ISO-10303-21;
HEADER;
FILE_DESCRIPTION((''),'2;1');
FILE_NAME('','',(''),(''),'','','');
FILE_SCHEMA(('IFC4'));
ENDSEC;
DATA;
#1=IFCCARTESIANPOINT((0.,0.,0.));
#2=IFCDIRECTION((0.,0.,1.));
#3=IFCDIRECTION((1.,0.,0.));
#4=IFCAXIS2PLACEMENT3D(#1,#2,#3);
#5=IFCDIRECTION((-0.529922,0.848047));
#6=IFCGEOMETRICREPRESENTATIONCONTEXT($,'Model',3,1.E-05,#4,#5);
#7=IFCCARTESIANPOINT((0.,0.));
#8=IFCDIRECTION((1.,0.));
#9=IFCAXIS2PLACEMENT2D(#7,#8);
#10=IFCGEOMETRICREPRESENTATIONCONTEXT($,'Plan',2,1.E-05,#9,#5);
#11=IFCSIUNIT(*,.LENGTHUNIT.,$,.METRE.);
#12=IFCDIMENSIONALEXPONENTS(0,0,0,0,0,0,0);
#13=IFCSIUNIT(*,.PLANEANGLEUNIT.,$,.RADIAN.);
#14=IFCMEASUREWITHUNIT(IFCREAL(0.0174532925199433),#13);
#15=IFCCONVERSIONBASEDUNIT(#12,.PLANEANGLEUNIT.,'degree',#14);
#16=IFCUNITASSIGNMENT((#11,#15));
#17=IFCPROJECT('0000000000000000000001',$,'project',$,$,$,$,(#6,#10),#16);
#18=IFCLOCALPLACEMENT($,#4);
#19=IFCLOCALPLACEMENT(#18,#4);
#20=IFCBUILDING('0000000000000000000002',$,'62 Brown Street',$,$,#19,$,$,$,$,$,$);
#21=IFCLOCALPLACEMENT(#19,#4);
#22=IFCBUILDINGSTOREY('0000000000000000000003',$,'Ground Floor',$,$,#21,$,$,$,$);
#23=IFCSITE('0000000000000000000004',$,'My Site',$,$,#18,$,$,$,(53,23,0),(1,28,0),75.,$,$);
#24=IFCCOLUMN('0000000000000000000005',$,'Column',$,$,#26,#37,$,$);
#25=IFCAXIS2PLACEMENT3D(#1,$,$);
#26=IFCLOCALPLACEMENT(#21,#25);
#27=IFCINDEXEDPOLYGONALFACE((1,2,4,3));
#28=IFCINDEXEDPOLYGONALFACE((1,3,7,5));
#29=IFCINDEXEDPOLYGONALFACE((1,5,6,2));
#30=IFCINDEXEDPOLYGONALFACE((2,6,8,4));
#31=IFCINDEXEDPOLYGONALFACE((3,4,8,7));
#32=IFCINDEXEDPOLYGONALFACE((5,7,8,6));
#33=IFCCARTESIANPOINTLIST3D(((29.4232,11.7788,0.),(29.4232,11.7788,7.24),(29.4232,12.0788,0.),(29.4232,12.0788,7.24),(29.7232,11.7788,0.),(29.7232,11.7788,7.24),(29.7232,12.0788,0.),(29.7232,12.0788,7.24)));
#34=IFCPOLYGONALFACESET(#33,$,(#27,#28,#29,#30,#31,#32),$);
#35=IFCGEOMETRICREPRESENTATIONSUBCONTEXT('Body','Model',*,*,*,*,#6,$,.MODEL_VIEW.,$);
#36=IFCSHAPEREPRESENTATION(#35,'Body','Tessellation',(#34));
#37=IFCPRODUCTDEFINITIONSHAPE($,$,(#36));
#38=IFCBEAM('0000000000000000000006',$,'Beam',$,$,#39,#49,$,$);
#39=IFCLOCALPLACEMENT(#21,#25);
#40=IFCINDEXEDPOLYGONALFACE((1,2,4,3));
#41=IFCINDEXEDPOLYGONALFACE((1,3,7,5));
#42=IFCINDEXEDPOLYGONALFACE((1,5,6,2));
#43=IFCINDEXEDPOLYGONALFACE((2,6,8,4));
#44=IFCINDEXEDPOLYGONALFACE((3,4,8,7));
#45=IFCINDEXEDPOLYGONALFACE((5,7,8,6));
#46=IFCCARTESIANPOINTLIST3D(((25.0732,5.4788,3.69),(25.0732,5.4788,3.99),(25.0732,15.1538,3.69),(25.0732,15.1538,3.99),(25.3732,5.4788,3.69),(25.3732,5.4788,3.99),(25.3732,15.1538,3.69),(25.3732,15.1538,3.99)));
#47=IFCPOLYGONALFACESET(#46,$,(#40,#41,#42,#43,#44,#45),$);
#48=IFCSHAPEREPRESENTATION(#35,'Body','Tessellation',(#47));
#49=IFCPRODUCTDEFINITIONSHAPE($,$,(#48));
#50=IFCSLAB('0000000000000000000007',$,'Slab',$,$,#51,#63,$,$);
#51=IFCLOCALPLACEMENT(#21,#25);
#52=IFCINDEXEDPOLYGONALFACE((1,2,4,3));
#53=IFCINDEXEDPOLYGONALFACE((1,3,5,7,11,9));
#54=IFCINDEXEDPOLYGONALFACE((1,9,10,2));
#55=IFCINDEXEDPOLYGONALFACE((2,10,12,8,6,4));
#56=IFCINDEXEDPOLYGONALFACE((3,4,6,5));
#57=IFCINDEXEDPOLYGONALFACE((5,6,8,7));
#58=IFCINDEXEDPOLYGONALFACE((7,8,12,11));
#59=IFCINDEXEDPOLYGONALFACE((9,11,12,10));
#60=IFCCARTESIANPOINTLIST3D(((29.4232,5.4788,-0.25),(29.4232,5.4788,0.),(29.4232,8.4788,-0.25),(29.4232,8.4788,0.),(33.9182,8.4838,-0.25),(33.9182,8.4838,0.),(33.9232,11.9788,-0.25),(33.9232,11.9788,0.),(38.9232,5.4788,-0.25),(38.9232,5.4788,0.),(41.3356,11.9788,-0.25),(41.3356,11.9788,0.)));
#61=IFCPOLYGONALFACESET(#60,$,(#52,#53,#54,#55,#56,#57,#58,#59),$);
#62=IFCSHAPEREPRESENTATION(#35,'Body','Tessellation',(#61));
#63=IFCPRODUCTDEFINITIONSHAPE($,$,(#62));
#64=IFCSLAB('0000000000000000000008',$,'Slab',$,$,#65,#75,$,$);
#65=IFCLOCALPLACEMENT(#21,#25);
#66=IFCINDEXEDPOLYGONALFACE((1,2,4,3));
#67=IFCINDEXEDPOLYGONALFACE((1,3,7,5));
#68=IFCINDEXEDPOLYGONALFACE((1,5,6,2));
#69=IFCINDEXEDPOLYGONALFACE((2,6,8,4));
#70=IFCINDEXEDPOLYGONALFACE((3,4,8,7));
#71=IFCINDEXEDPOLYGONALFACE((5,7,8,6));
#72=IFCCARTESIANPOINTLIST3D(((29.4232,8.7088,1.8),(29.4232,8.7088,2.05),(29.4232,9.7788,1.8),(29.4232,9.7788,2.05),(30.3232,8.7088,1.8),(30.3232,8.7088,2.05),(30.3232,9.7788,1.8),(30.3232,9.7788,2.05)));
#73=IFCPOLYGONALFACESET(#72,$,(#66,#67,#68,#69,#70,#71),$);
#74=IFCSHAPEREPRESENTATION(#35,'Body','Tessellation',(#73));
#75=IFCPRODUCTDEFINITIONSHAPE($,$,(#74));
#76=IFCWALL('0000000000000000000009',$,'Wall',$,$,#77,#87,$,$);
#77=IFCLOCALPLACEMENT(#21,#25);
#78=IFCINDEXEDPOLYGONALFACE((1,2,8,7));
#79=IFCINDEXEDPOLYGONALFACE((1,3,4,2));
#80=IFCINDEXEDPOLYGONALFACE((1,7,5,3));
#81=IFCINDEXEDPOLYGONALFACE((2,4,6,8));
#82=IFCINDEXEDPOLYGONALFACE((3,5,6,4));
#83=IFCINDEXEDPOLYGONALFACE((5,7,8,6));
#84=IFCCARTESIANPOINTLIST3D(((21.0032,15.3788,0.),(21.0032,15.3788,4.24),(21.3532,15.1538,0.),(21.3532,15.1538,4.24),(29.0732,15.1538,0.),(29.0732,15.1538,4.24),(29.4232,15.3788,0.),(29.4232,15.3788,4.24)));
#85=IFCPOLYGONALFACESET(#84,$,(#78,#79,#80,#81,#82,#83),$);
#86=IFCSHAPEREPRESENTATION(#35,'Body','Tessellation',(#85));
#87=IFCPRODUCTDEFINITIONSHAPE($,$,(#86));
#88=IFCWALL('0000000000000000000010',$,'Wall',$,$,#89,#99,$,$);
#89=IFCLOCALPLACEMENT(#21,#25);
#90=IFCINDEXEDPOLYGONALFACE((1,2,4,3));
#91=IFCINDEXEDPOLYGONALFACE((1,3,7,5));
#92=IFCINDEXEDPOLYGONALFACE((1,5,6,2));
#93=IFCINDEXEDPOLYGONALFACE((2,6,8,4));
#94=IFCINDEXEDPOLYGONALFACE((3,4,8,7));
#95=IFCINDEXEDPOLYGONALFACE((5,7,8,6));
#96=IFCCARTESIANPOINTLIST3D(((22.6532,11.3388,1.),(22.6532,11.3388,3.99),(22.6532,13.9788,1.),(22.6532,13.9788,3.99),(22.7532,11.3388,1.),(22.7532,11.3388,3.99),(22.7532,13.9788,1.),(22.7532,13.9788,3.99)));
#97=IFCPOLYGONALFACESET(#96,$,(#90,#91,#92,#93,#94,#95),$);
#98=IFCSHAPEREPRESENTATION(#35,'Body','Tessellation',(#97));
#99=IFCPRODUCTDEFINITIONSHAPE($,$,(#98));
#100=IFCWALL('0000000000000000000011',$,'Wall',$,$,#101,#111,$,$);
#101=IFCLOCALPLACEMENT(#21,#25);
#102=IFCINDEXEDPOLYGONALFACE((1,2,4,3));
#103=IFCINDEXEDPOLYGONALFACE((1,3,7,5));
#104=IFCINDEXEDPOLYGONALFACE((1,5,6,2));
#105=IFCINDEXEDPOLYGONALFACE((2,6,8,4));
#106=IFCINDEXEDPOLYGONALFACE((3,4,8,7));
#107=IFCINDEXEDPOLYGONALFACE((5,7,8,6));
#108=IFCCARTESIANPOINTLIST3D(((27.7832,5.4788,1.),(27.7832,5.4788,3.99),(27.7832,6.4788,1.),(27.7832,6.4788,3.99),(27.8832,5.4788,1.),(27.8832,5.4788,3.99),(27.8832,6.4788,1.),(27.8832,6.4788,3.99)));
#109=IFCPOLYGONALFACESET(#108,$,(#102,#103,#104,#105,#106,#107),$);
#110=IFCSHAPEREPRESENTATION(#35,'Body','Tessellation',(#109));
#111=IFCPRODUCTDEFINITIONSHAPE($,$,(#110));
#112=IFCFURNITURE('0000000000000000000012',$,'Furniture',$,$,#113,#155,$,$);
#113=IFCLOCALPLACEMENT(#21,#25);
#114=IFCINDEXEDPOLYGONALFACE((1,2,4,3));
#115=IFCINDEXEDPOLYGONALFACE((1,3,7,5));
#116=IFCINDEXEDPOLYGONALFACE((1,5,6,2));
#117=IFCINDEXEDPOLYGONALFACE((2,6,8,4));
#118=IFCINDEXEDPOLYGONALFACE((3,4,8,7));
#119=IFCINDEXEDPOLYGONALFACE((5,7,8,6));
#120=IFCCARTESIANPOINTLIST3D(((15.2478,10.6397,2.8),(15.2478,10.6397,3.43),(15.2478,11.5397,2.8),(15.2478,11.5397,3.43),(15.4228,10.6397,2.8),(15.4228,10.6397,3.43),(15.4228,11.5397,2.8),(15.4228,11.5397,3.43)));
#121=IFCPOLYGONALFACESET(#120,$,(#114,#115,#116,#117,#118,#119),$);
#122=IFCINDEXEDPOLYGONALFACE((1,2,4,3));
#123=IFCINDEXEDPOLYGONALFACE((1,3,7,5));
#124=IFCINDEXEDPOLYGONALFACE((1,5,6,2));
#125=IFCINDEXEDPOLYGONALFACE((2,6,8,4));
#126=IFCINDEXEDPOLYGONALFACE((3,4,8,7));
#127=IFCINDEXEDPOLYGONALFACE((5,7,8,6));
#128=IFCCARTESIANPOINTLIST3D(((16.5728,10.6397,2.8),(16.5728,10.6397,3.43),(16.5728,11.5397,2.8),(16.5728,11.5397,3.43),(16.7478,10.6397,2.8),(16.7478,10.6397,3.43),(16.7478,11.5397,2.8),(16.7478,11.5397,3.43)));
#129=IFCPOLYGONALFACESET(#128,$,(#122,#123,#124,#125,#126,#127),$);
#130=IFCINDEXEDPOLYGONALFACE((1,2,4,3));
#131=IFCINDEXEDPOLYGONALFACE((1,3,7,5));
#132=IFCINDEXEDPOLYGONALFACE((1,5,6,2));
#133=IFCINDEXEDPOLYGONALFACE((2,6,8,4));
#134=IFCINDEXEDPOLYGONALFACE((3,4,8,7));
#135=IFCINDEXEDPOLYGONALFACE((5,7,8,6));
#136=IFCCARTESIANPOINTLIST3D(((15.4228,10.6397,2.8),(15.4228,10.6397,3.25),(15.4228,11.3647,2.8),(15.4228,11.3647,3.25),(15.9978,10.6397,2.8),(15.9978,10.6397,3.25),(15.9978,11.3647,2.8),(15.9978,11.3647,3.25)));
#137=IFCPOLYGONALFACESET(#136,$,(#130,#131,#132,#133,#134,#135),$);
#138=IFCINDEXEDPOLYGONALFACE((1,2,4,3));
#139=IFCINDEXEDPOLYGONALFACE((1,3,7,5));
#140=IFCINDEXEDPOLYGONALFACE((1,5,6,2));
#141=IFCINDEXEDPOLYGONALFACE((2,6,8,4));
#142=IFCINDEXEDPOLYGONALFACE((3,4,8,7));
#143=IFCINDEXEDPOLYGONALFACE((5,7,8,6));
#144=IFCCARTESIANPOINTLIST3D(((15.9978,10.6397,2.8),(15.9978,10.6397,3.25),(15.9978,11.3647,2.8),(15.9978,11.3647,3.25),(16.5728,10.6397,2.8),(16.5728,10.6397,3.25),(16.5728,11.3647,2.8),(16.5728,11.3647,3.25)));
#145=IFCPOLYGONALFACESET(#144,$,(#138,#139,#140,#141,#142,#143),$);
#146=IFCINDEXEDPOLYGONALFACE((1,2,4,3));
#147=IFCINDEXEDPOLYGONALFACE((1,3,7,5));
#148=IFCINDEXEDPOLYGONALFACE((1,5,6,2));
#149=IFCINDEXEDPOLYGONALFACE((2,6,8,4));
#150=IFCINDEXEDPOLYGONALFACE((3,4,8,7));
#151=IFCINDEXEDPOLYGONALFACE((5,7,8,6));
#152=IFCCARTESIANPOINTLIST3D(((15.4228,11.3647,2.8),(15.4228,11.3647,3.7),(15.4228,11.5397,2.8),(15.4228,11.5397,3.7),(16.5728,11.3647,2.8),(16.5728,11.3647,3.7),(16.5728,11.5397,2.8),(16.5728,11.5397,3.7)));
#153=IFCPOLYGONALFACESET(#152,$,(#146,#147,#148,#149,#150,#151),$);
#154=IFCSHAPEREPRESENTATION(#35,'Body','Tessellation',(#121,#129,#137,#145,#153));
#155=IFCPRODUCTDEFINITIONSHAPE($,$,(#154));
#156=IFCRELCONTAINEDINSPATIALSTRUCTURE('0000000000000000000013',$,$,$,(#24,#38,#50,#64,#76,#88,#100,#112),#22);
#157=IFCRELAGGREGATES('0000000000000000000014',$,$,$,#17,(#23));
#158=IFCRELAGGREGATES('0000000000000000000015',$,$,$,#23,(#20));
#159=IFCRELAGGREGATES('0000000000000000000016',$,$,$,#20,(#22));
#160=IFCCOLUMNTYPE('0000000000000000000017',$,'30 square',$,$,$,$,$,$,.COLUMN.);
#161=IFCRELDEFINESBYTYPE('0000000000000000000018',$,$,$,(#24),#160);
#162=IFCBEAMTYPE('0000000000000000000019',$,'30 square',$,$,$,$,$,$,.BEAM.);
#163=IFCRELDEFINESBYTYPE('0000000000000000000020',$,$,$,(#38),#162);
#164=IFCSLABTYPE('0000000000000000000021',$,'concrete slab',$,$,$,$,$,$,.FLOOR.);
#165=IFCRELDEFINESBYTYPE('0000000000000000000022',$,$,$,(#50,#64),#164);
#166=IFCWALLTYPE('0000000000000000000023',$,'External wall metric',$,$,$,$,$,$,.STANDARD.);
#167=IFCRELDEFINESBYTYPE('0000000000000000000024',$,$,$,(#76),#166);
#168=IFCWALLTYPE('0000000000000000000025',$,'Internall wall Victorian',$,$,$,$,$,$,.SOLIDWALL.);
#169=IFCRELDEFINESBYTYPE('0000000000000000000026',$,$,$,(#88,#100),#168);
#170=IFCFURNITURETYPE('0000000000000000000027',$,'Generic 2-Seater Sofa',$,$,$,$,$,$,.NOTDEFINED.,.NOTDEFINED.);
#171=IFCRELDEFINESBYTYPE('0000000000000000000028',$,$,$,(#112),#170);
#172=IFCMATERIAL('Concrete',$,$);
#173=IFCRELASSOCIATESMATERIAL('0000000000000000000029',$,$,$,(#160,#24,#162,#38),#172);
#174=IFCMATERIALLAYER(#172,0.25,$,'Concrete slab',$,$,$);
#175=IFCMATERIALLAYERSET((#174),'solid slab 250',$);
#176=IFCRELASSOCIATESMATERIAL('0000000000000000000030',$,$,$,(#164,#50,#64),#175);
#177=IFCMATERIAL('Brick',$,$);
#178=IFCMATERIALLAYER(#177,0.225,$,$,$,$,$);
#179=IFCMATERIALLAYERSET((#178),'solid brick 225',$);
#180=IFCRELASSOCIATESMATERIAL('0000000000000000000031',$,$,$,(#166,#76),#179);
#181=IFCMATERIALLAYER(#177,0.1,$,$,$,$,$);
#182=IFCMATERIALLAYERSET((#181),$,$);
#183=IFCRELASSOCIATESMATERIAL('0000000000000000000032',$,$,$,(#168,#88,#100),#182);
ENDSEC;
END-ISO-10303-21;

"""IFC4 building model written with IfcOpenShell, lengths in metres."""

from ifc_helpers import new_model, entity, si_unit, converted_unit, direction, frame, origin_with_axes, origin_2d_with_axis, place, context, subcontext, project, spatial, line, indexed_curve, rectangle, outline, extrude, clip, halfspace, shape, source, transform, mapped, material, layer, layer_set, layer_usage, material_profile, profile_set, profile_usage, type_object, type_shapes, element, save


model = new_model("IFC4")

# Units and contexts
model_context = context("Model", 3, precision=1e-05, world=origin_with_axes(), true_north=direction((-0.529922, 0.848047)))
plan_context = context("Plan", 2, precision=1e-05, world=origin_2d_with_axis(), true_north=direction((-0.529922, 0.848047)))
body_context_1 = subcontext(model_context, "Body", "Model", "MODEL_VIEW")
body_context_2 = subcontext(plan_context, "Body", "Plan", "PLAN_VIEW")
ifc_project = project(units=[si_unit("LENGTHUNIT", "METRE"), converted_unit("PLANEANGLEUNIT", "degree", entity("IfcReal", 0.0174532925199433), si_unit("PLANEANGLEUNIT", "RADIAN"), dimensions=[0, 0, 0, 0, 0, 0, 0])], contexts=[model_context, plan_context])

# Site, building, storey
site_placement = place(None, origin_with_axes())
site = spatial("IfcSite", under=ifc_project, at=site_placement, Name="My Site", RefLatitude=(53, 23, 0), RefLongitude=(1, 28, 0), RefElevation=75.0)
building_placement = place(site_placement, origin_with_axes())
building = spatial("IfcBuilding", under=site, at=building_placement, Name="62 Brown Street")
storey_placement = place(building_placement, origin_with_axes())
storey = spatial("IfcBuildingStorey", under=building, at=storey_placement, Name="Ground Floor")

# Column
ifc_material_1 = material(Name="Concrete")
ifc_material_profile_1 = material_profile(ifc_material_1, rectangle(XDim=0.3, YDim=0.3))
ifc_profile_set_1 = profile_set([ifc_material_profile_1])
ifc_profile_usage_1 = profile_usage(ifc_profile_set_1, cardinal=5)
column_type = type_object("IfcColumnType", Name="30 square", PredefinedType="COLUMN", material=ifc_profile_set_1)
column_1_placement = place(storey_placement, frame((29.5732, 11.9288, 0.0), z_axis=(0.0, 0.0, 1.0), x_axis=(1.0, 0.0, 0.0)))
element("IfcColumn", 1, at=column_1_placement, inside=storey, type_object=column_type, material=ifc_profile_usage_1, Name="Column", context=body_context_1, shape_type="SweptSolid", body=[
    extrude(rectangle(XDim=0.3, YDim=0.3), origin_with_axes(), (0.0, 0.0, 1.0), 7.24),
])

# Beam
ifc_material_profile_2 = material_profile(ifc_material_1, rectangle(XDim=0.3, YDim=0.3))
ifc_profile_set_2 = profile_set([ifc_material_profile_2])
ifc_profile_usage_2 = profile_usage(ifc_profile_set_2, cardinal=5)
beam_type = type_object("IfcBeamType", Name="30 square", PredefinedType="BEAM", material=ifc_profile_set_2)
beam_placement = place(storey_placement, frame((25.2232, 5.4788, 3.84), z_axis=(0.0, 1.0, 0.0), x_axis=(-1.0, 0.0, 0.0)))
element("IfcBeam", 2, at=beam_placement, inside=storey, type_object=beam_type, material=ifc_profile_usage_2, Name="Beam", context=body_context_1, shape_type="SweptSolid", body=[
    extrude(rectangle(XDim=0.3, YDim=0.3), origin_with_axes(), (0.0, 0.0, 1.0), 9.675),
])

# Slabs
ifc_layer_1 = layer(ifc_material_1, 0.25, Name="Concrete slab")
ifc_layer_set_1 = layer_set([ifc_layer_1], Name="solid slab 250")
ifc_layer_usage_1 = layer_usage(ifc_layer_set_1, "AXIS3", "POSITIVE", 0.0)
slab_type = type_object("IfcSlabType", Name="concrete slab", PredefinedType="FLOOR", material=ifc_layer_set_1)
slab_1_placement = place(storey_placement, frame((29.4232, 5.4788, -0.25), z_axis=(0.0, 0.0, 1.0), x_axis=(1.0, 0.0, 0.0)))
element("IfcSlab", 3, at=slab_1_placement, inside=storey, type_object=slab_type, material=ifc_layer_usage_1, Name="Slab", context=body_context_1, shape_type="SweptSolid", body=[
    extrude(outline(indexed_curve([(0.0, 0.0), (9.5, 0.0), (11.9124, 6.5), (0.0, 3.0), (4.5, 6.5), (4.495, 3.005)], segments=[line(1, 2), line(2, 3), line(3, 5), line(5, 6), line(6, 4), line(4, 1)], self_intersect=False)), None, (0.0, 0.0, 1.0), 0.25),
])
ifc_layer_usage_2 = layer_usage(ifc_layer_set_1, "AXIS3", "POSITIVE", 0.0)
slab_2_placement = place(storey_placement, frame((29.4232, 8.7088, 1.8), z_axis=(0.0, 0.0, 1.0), x_axis=(1.0, 0.0, 0.0)))
element("IfcSlab", 4, at=slab_2_placement, inside=storey, type_object=slab_type, material=ifc_layer_usage_2, Name="Slab", context=body_context_1, shape_type="SweptSolid", body=[
    extrude(outline(indexed_curve([(0.9, 1.07), (0.9, 0.0), (0.0, 0.0), (0.0, 1.07)], segments=[line(3, 2), line(2, 1), line(1, 4), line(4, 3)], self_intersect=False)), None, (0.0, 0.0, 1.0), 0.25),
])

# Walls
ifc_material_2 = material(Name="Brick")
ifc_layer_2 = layer(ifc_material_2, 0.225)
ifc_layer_set_2 = layer_set([ifc_layer_2], Name="solid brick 225")
wall_type_1 = type_object("IfcWallType", Name="External wall metric", PredefinedType="STANDARD", material=ifc_layer_set_2)
ifc_layer_usage_3 = layer_usage(ifc_layer_set_2, "AXIS2", "POSITIVE", 0.0)
wall_1_placement = place(storey_placement, frame((29.4232, 15.3788, 0.0), z_axis=(0.0, 0.0, 1.0), x_axis=(-1.0, 0.0, 0.0)))
element("IfcWall", 5, at=wall_1_placement, inside=storey, type_object=wall_type_1, material=ifc_layer_usage_3, Name="Wall", context=body_context_1, shape_type="Clipping", body=[
    clip(clip(extrude(outline(indexed_curve([(0.0, 0.0), (0.0, 0.225), (8.42, 0.225), (8.42, 0.0), (0.0, 0.0)], self_intersect=False)), origin_with_axes(), (0.0, 0.0, 1.0), 4.24), halfspace(frame((8.42, 0.0, 0.0), z_axis=(0.540756, 0.841179, 0.0), x_axis=(-0.841179, 0.540756, 0.0)), False)), halfspace(frame((0.0, 0.0, 0.0), z_axis=(-0.540758, 0.841178, 0.0), x_axis=(0.841178, 0.540758, 0.0)), False)),
])
ifc_layer_3 = layer(ifc_material_2, 0.1)
ifc_layer_set_3 = layer_set([ifc_layer_3])
ifc_layer_usage_4 = layer_usage(ifc_layer_set_3, "AXIS2", "POSITIVE", 0.0)
wall_type_2 = type_object("IfcWallType", Name="Internall wall Victorian", PredefinedType="SOLIDWALL", material=ifc_layer_set_3)
wall_2_placement = place(storey_placement, frame((22.7532, 11.3388, 1.0), z_axis=(0.0, 0.0, 1.0), x_axis=(0.0, 1.0, 0.0)))
element("IfcWall", 6, at=wall_2_placement, inside=storey, type_object=wall_type_2, material=ifc_layer_usage_4, Name="Wall", context=body_context_1, shape_type="SweptSolid", body=[
    extrude(outline(indexed_curve([(0.0, 0.0), (0.0, 0.1), (2.64, 0.1), (2.64, 0.0), (0.0, 0.0)], self_intersect=False)), origin_with_axes(), (0.0, 0.0, 1.0), 2.99),
])
ifc_layer_usage_5 = layer_usage(ifc_layer_set_3, "AXIS2", "POSITIVE", 0.0)
wall_3_placement = place(storey_placement, frame((27.8832, 5.4788, 1.0), z_axis=(0.0, 0.0, 1.0), x_axis=(0.0, 1.0, 0.0)))
element("IfcWall", 7, at=wall_3_placement, inside=storey, type_object=wall_type_2, material=ifc_layer_usage_5, Name="Wall", context=body_context_1, shape_type="SweptSolid", body=[
    extrude(outline(indexed_curve([(0.0, 0.0), (0.0, 0.1), (1.0, 0.1), (1.0, 0.0), (0.0, 0.0)], self_intersect=False)), origin_with_axes(), (0.0, 0.0, 1.0), 2.99),
])

# Furniture
furniture_type_1 = type_object("IfcFurnitureType", Name="Generic 2-Seater Sofa", AssemblyPlace="NOTDEFINED", PredefinedType="NOTDEFINED")
shared_shape_1 = source(origin_with_axes(), body_context_1, "Body", "SweptSolid", [
    extrude(outline(indexed_curve([(0.0, 0.0), (0.175, 0.0), (0.175, 0.9), (0.0, 0.9)], segments=[line(1, 2, 3, 4, 1)])), frame((-0.75, -0.9, 0.0), z_axis=(0.0, 0.0, 1.0), x_axis=(1.0, 0.0, 0.0)), (0.0, 0.0, 1.0), 0.63),
    extrude(outline(indexed_curve([(0.0, 0.0), (0.175, 0.0), (0.175, 0.9), (0.0, 0.9)], segments=[line(1, 2, 3, 4, 1)])), frame((0.575, -0.9, 0.0), z_axis=(0.0, 0.0, 1.0), x_axis=(1.0, 0.0, 0.0)), (0.0, 0.0, 1.0), 0.63),
    extrude(outline(indexed_curve([(0.175, 0.0), (0.75, 0.0), (0.75, 0.725), (0.175, 0.725)], segments=[line(1, 2, 3, 4, 1)])), frame((-0.75, -0.9, 0.0), z_axis=(0.0, 0.0, 1.0), x_axis=(1.0, 0.0, 0.0)), (0.0, 0.0, 1.0), 0.45),
    extrude(outline(indexed_curve([(0.75, 0.0), (1.325, 0.0), (1.325, 0.725), (0.75, 0.725)], segments=[line(1, 2, 3, 4, 1)])), frame((-0.75, -0.9, 0.0), z_axis=(0.0, 0.0, 1.0), x_axis=(1.0, 0.0, 0.0)), (0.0, 0.0, 1.0), 0.45),
    extrude(outline(indexed_curve([(0.175, 0.725), (1.325, 0.725), (1.325, 0.9), (0.175, 0.9)], segments=[line(1, 2, 3, 4, 1)])), frame((-0.75, -0.9, 0.0), z_axis=(0.0, 0.0, 1.0), x_axis=(1.0, 0.0, 0.0)), (0.0, 0.0, 1.0), 0.9),
])
shared_shape_2 = source(origin_with_axes(), body_context_2, "Body", "Curve2D", [
    entity("IfcIndexedPolyCurve", entity("IfcCartesianPointList2D", [[-0.75, -0.9], [-0.575, -0.9], [-0.575, 0.0], [-0.75, 0.0]]), [entity("IfcLineIndex", [1, 2, 3, 4, 1])]),
    entity("IfcIndexedPolyCurve", entity("IfcCartesianPointList2D", [[0.575, -0.9], [0.75, -0.9], [0.75, 0.0], [0.575, 0.0]]), [entity("IfcLineIndex", [1, 2, 3, 4, 1])]),
    entity("IfcIndexedPolyCurve", entity("IfcCartesianPointList2D", [[-0.575, -0.9], [0.0, -0.9], [0.0, -0.175], [-0.575, -0.175]]), [entity("IfcLineIndex", [1, 2, 3, 4, 1])]),
    entity("IfcIndexedPolyCurve", entity("IfcCartesianPointList2D", [[0.0, -0.9], [0.575, -0.9], [0.575, -0.175], [0.0, -0.175]]), [entity("IfcLineIndex", [1, 2, 3, 4, 1])]),
    entity("IfcIndexedPolyCurve", entity("IfcCartesianPointList2D", [[-0.575, -0.175], [0.575, -0.175], [0.575, 0.0], [-0.575, 0.0]]), [entity("IfcLineIndex", [1, 2, 3, 4, 1])]),
])
type_shapes(furniture_type_1, [shared_shape_1, shared_shape_2])
for number, where, z_axis, x_axis, name in (
    (8, (15.9978, 11.5397, 2.8), (0.0, 0.0, 1.0), (1.0, 0.0, 0.0), "Furniture"),
):
    element("IfcFurniture", number, at=place(storey_placement, frame(where, z_axis=z_axis, x_axis=x_axis)), inside=storey, type_object=furniture_type_1, Name=name, shapes=[
        shape(body_context_1, "Body", "MappedRepresentation", [mapped(shared_shape_1, transform((0.0, 0.0, 0.0), x_axis=(1.0, 0.0, 0.0), y_axis=(0.0, 1.0, 0.0), z_axis=(0.0, 0.0, 1.0), scale=1.0))]),
        shape(body_context_2, "Body", "MappedRepresentation", [mapped(shared_shape_2, transform((0.0, 0.0, 0.0), x_axis=(1.0, 0.0, 0.0), y_axis=(0.0, 1.0, 0.0), z_axis=(0.0, 0.0, 1.0), scale=1.0))]),
    ])

save(model, "model.ifc")
